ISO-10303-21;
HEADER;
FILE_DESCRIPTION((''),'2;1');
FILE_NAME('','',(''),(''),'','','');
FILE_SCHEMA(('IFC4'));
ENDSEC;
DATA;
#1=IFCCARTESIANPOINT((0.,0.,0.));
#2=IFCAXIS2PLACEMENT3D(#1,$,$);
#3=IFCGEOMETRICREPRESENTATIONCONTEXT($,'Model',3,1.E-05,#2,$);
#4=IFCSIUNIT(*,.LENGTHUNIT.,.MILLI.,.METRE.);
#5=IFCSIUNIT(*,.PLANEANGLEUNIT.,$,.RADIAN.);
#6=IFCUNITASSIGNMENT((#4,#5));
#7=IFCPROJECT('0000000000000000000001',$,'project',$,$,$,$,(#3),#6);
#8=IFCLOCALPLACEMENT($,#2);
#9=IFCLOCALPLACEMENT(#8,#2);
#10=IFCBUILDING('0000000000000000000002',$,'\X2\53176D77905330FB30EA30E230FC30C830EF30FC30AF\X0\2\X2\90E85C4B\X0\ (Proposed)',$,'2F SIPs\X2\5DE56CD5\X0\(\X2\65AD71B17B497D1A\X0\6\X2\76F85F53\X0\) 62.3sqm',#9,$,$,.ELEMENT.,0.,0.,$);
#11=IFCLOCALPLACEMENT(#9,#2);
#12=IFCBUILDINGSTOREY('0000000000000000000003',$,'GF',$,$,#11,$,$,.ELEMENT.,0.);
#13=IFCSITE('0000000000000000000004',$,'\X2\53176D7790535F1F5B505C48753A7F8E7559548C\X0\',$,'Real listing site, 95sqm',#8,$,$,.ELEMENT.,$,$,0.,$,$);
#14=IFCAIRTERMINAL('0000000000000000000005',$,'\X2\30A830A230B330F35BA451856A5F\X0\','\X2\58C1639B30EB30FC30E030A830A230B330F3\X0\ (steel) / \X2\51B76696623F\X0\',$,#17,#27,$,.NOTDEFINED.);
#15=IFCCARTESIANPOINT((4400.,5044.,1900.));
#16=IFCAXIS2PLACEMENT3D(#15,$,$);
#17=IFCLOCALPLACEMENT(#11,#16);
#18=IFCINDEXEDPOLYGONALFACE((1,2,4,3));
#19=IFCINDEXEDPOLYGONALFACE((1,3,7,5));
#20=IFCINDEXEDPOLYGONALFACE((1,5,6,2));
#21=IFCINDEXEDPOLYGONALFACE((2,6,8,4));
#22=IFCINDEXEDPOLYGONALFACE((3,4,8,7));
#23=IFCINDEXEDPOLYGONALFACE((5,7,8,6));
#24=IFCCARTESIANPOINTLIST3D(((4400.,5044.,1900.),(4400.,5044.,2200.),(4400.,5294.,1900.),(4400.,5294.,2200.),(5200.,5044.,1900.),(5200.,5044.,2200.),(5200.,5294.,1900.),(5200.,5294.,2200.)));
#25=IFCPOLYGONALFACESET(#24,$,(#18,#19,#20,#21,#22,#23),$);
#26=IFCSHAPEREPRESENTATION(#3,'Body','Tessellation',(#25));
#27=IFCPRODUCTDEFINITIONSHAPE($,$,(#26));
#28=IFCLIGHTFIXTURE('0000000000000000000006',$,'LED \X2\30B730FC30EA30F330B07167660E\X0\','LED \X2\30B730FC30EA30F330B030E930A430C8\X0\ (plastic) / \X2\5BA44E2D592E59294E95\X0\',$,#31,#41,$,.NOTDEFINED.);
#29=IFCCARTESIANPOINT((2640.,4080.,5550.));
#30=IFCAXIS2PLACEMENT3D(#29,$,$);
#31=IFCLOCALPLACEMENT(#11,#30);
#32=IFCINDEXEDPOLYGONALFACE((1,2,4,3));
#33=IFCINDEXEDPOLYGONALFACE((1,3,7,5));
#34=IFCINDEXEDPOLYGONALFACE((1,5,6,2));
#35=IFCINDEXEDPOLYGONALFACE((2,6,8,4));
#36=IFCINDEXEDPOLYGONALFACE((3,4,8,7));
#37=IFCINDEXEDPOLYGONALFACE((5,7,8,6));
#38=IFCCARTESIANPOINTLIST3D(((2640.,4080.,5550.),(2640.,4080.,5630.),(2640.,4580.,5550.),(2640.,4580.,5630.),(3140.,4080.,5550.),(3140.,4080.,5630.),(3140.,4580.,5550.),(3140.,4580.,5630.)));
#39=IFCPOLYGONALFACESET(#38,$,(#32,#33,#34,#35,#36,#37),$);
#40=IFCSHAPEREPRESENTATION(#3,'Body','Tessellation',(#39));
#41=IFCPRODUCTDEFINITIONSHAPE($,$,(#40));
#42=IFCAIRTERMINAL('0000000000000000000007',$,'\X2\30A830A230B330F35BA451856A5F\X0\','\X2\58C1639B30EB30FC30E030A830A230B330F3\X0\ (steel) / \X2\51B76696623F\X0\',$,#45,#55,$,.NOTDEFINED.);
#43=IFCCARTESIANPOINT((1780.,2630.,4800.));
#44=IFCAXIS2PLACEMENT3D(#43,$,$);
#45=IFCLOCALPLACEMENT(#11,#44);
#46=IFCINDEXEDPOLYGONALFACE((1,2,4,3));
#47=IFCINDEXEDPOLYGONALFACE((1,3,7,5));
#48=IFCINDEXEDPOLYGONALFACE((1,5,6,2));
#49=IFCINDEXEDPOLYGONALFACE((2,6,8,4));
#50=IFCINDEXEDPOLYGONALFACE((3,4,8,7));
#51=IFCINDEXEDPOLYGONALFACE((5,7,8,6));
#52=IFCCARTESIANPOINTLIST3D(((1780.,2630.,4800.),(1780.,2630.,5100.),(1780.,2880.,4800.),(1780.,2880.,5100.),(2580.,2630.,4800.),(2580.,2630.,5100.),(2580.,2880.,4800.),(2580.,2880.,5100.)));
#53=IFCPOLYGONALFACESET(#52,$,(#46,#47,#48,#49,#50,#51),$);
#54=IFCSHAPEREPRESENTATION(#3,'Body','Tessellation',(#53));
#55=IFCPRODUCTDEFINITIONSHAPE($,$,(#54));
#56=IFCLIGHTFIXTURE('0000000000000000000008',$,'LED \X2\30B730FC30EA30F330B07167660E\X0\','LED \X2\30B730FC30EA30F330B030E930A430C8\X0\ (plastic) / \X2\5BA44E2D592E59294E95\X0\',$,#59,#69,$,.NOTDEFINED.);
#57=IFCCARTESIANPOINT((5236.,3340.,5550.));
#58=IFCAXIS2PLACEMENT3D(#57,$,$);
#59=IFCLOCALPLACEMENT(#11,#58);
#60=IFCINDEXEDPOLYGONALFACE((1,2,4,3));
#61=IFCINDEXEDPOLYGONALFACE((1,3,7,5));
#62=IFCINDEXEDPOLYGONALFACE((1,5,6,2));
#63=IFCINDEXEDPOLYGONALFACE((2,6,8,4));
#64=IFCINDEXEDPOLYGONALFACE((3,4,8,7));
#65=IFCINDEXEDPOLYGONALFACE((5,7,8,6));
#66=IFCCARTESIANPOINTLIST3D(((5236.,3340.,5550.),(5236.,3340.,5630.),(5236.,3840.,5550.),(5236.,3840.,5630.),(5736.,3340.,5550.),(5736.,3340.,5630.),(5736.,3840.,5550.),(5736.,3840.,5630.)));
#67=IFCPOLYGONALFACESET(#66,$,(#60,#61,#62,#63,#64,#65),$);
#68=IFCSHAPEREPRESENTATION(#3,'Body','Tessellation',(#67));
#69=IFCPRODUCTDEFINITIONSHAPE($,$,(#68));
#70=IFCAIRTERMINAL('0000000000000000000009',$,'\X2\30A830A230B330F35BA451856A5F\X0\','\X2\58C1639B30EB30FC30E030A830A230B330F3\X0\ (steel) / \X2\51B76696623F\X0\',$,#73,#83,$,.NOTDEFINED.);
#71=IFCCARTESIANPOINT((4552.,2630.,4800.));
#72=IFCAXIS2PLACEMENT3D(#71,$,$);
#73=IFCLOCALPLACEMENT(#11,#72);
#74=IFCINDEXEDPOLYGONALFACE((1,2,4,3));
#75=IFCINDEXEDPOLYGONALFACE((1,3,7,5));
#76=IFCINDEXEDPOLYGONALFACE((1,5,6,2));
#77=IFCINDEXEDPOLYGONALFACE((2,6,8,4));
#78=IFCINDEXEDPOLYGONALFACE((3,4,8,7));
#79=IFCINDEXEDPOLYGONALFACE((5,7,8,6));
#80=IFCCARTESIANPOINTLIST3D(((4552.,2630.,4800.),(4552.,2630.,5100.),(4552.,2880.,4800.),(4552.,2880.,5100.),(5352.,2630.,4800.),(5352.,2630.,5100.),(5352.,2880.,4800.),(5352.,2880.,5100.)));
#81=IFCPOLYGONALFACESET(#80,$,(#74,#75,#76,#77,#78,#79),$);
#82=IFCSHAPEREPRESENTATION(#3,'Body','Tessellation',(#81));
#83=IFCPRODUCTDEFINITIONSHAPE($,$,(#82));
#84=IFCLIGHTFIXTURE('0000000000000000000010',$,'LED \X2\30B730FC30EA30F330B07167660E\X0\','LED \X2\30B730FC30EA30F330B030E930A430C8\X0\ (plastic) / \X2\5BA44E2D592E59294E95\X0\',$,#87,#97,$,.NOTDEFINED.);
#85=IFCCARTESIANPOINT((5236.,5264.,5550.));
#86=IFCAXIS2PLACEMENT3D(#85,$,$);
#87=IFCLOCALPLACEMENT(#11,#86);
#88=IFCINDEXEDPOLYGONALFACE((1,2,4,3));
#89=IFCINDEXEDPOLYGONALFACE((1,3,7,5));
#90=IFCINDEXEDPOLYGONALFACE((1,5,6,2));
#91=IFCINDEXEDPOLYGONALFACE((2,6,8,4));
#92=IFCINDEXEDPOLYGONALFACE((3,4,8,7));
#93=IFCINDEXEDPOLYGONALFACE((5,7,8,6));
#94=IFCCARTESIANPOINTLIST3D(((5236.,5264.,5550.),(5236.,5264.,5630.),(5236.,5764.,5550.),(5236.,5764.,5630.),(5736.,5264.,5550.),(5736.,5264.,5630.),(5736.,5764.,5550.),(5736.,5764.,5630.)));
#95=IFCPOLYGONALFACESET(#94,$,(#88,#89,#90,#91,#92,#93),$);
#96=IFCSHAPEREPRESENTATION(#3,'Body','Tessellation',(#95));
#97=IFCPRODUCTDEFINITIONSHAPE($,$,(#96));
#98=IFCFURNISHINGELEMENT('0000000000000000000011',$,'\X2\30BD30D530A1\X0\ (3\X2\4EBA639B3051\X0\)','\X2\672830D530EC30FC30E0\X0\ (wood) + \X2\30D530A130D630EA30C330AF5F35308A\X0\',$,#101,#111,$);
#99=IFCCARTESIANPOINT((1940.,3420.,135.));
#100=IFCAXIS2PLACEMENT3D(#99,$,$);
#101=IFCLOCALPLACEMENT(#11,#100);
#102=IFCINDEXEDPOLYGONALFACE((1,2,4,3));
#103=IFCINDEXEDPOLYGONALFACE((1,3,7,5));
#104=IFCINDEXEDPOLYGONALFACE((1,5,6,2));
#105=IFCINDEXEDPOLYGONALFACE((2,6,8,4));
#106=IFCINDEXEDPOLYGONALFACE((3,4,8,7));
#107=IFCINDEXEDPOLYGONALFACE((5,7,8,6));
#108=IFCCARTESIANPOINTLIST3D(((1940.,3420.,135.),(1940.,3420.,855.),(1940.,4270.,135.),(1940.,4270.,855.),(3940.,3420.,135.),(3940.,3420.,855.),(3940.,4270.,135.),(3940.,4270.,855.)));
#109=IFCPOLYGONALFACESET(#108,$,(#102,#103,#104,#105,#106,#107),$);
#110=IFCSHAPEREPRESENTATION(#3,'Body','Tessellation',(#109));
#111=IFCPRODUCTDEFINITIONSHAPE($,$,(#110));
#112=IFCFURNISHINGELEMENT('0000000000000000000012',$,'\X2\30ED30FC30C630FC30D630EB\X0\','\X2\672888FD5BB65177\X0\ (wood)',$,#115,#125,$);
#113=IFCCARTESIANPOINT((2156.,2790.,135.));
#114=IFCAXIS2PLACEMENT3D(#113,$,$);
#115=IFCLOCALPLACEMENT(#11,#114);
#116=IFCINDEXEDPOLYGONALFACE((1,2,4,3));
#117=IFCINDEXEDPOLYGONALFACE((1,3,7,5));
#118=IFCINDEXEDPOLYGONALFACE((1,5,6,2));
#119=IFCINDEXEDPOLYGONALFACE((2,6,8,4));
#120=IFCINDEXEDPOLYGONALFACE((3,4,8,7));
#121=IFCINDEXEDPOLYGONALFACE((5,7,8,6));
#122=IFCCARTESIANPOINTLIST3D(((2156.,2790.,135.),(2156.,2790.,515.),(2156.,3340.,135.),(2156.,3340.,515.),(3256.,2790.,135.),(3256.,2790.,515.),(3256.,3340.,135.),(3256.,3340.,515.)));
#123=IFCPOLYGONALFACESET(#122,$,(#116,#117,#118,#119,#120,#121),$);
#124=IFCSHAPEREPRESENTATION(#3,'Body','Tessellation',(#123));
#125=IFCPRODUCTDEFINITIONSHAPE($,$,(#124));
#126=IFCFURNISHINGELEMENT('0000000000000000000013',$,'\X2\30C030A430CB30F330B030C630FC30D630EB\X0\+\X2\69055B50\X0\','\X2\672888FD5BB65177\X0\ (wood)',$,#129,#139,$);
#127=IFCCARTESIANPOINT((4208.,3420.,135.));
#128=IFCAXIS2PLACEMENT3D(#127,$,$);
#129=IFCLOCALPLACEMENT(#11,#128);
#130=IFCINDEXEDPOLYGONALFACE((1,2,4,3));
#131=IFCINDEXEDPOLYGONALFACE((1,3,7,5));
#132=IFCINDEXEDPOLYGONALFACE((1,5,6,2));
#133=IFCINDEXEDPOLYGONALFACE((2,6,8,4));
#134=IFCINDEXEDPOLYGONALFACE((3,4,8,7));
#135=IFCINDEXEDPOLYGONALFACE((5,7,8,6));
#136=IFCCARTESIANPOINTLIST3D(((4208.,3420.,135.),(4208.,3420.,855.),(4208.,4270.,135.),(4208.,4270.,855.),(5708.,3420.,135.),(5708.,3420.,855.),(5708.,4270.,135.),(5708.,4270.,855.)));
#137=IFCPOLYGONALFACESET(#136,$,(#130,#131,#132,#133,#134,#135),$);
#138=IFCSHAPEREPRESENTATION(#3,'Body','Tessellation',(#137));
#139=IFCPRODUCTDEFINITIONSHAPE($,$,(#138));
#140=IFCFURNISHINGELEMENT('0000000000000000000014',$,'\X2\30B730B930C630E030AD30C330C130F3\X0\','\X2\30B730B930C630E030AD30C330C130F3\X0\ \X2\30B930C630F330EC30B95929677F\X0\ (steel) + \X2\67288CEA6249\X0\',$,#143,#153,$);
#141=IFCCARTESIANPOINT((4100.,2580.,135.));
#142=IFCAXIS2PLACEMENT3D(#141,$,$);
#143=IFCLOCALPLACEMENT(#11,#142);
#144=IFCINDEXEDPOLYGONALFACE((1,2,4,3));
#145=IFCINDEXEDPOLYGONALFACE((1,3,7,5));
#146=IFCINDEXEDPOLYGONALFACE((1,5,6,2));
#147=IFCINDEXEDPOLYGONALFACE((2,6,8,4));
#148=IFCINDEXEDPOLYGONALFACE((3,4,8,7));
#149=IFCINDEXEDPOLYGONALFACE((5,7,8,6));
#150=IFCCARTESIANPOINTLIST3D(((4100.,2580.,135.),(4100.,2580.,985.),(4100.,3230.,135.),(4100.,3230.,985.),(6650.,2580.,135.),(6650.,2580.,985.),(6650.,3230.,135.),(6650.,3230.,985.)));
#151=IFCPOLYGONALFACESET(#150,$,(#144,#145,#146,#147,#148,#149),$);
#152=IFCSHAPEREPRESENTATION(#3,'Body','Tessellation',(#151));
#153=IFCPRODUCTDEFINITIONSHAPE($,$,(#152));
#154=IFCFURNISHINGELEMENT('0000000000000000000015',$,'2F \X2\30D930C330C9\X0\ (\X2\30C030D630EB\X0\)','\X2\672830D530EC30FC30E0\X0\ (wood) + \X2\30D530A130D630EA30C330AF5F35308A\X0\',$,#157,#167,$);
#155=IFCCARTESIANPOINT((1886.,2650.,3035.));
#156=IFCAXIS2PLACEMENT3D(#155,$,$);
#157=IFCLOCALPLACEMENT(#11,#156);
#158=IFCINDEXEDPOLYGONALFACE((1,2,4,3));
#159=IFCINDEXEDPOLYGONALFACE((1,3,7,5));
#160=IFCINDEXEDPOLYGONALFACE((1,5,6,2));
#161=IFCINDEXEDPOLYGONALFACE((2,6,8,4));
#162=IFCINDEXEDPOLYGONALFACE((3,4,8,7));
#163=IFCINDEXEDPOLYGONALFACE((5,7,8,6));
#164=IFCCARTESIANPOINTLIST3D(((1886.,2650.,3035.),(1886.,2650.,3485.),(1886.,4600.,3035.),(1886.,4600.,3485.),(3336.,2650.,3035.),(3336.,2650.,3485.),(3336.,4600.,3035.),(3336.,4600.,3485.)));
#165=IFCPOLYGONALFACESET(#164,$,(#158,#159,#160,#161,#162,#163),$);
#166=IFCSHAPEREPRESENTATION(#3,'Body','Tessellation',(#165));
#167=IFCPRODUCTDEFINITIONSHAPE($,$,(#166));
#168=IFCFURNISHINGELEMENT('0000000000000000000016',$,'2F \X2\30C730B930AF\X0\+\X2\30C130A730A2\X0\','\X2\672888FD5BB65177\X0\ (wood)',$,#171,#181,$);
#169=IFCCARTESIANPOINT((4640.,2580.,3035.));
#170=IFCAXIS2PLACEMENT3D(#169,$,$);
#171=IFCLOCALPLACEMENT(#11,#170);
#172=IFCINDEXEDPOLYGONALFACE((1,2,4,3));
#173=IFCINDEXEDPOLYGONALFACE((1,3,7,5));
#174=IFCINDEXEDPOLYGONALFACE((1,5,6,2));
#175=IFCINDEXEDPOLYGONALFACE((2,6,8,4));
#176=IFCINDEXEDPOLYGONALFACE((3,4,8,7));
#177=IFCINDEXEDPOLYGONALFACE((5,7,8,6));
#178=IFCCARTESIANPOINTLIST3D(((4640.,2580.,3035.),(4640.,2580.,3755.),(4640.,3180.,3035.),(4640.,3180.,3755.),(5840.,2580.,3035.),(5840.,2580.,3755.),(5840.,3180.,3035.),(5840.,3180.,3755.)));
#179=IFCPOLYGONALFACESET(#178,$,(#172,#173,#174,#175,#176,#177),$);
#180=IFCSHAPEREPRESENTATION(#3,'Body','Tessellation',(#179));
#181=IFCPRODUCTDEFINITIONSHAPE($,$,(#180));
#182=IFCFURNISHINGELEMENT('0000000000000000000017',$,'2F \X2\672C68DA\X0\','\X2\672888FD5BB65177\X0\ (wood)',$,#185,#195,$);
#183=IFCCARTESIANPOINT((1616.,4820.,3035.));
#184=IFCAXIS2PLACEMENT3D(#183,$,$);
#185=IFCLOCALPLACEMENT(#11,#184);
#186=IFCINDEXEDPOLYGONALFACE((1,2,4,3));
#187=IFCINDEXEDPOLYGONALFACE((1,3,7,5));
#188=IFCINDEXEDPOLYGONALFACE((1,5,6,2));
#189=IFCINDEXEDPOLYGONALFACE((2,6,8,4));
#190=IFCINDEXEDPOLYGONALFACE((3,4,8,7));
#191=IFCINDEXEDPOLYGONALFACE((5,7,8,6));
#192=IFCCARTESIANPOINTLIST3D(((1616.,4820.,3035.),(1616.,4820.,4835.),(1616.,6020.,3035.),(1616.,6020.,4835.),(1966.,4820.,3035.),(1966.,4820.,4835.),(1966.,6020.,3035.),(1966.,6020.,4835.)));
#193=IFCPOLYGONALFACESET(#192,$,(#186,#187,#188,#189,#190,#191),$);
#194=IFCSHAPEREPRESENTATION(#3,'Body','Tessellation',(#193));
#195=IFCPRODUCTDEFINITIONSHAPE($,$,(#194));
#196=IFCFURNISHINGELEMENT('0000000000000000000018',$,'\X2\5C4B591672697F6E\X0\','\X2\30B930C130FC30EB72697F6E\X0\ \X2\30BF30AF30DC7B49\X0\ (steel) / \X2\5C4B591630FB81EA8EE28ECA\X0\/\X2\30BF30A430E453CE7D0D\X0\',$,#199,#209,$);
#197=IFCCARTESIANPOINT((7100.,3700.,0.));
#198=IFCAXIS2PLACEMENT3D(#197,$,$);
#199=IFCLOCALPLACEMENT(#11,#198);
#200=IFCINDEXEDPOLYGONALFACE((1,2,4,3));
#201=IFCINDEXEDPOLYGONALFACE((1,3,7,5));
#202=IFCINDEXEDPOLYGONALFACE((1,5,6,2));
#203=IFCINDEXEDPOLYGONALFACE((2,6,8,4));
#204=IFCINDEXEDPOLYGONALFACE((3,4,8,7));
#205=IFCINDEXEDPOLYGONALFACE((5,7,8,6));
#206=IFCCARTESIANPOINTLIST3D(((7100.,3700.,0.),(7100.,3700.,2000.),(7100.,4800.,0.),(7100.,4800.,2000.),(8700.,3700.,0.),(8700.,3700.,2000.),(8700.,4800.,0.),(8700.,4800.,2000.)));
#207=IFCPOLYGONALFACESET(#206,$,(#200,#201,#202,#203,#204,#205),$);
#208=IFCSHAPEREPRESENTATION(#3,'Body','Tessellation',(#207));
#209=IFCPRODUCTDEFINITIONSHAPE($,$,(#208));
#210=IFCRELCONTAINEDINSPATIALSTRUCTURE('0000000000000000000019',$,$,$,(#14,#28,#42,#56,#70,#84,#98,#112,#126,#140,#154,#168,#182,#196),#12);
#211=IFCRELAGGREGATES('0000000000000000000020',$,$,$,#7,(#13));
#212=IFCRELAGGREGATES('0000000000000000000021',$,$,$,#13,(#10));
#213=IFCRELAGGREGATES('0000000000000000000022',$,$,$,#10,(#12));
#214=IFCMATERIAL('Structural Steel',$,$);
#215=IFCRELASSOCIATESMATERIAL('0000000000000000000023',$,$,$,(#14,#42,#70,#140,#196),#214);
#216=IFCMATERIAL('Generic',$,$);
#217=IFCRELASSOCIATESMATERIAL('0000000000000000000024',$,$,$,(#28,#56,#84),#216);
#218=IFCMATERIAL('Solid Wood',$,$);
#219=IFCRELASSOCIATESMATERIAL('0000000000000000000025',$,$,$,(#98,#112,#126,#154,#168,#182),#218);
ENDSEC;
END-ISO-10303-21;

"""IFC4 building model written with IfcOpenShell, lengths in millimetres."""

from ifc_helpers import new_model, si_unit, frame, frame_2d, origin, place, context, project, spatial, rectangle, extrude, material, element, save


model = new_model("IFC4")

# Units and contexts
model_context = context("Model", 3, precision=1e-05, world=origin())
ifc_project = project(units=[si_unit("LENGTHUNIT", "METRE", prefix="MILLI"), si_unit("PLANEANGLEUNIT", "RADIAN")], contexts=[model_context])

# Site, building, storey
site_placement = place(None, origin())
site = spatial("IfcSite", under=ifc_project, at=site_placement, Name="北海道弟子屈町美留和", ObjectType="Real listing site, 95sqm", CompositionType="ELEMENT", RefElevation=0.0)
building_placement = place(site_placement, origin())
building = spatial("IfcBuilding", under=site, at=building_placement, Name="北海道・リモートワーク2部屋 (Proposed)", ObjectType="2F SIPs工法(断熱等級6相当) 62.3sqm", CompositionType="ELEMENT", ElevationOfRefHeight=0.0, ElevationOfTerrain=0.0)
storey_placement = place(building_placement, origin())
storey = spatial("IfcBuildingStorey", under=building, at=storey_placement, Name="GF", CompositionType="ELEMENT", Elevation=0.0)

# Shared definitions
ifc_material_1 = material(Name="Solid Wood")

# Shared definitions
ifc_material_2 = material(Name="Structural Steel")

# Shared definitions
ifc_material_3 = material(Name="Generic")

# Air terminal
air_terminal_1_placement = place(storey_placement, frame((4400.0, 5044.0, 1900.0)))
element("IfcAirTerminal", 1, at=air_terminal_1_placement, inside=storey, material=ifc_material_2, Name="エアコン室内機", Description="壁掛ルームエアコン (steel) / 冷暖房", PredefinedType="NOTDEFINED", context=model_context, shape_type="SweptSolid", body=[
    extrude(rectangle(XDim=800.0, YDim=250.0, at=frame_2d((400.0, 125.0))), frame((4400.0, 5044.0, 1900.0)), (0.0, 0.0, 1.0), 300.0),
])

# Light fixture
light_fixture_1_placement = place(storey_placement, frame((2640.0, 4080.0, 5550.0)))
element("IfcLightFixture", 2, at=light_fixture_1_placement, inside=storey, material=ifc_material_3, Name="LED シーリング照明", Description="LED シーリングライト (plastic) / 室中央天井", PredefinedType="NOTDEFINED", context=model_context, shape_type="SweptSolid", body=[
    extrude(rectangle(XDim=500.0, YDim=500.0, at=frame_2d((250.0, 250.0))), frame((2640.0, 4080.0, 5550.0)), (0.0, 0.0, 1.0), 80.0),
])

# Air terminal
air_terminal_2_placement = place(storey_placement, frame((1780.0, 2630.0, 4800.0)))
element("IfcAirTerminal", 3, at=air_terminal_2_placement, inside=storey, material=ifc_material_2, Name="エアコン室内機", Description="壁掛ルームエアコン (steel) / 冷暖房", PredefinedType="NOTDEFINED", context=model_context, shape_type="SweptSolid", body=[
    extrude(rectangle(XDim=800.0, YDim=250.0, at=frame_2d((400.0, 125.0))), frame((1780.0, 2630.0, 4800.0)), (0.0, 0.0, 1.0), 300.0),
])

# Light fixture
light_fixture_2_placement = place(storey_placement, frame((5236.0, 3340.0, 5550.0)))
element("IfcLightFixture", 4, at=light_fixture_2_placement, inside=storey, material=ifc_material_3, Name="LED シーリング照明", Description="LED シーリングライト (plastic) / 室中央天井", PredefinedType="NOTDEFINED", context=model_context, shape_type="SweptSolid", body=[
    extrude(rectangle(XDim=500.0, YDim=500.0, at=frame_2d((250.0, 250.0))), frame((5236.0, 3340.0, 5550.0)), (0.0, 0.0, 1.0), 80.0),
])

# Air terminal
air_terminal_3_placement = place(storey_placement, frame((4552.0, 2630.0, 4800.0)))
element("IfcAirTerminal", 5, at=air_terminal_3_placement, inside=storey, material=ifc_material_2, Name="エアコン室内機", Description="壁掛ルームエアコン (steel) / 冷暖房", PredefinedType="NOTDEFINED", context=model_context, shape_type="SweptSolid", body=[
    extrude(rectangle(XDim=800.0, YDim=250.0, at=frame_2d((400.0, 125.0))), frame((4552.0, 2630.0, 4800.0)), (0.0, 0.0, 1.0), 300.0),
])

# Light fixture
light_fixture_3_placement = place(storey_placement, frame((5236.0, 5264.0, 5550.0)))
element("IfcLightFixture", 6, at=light_fixture_3_placement, inside=storey, material=ifc_material_3, Name="LED シーリング照明", Description="LED シーリングライト (plastic) / 室中央天井", PredefinedType="NOTDEFINED", context=model_context, shape_type="SweptSolid", body=[
    extrude(rectangle(XDim=500.0, YDim=500.0, at=frame_2d((250.0, 250.0))), frame((5236.0, 5264.0, 5550.0)), (0.0, 0.0, 1.0), 80.0),
])

# Furnishing elements
furnishing_1_placement = place(storey_placement, frame((1940.0, 3420.0, 135.0)))
element("IfcFurnishingElement", 7, at=furnishing_1_placement, inside=storey, material=ifc_material_1, Name="ソファ (3人掛け)", Description="木フレーム (wood) + ファブリック張り", context=model_context, shape_type="SweptSolid", body=[
    extrude(rectangle(XDim=2000.0, YDim=850.0, at=frame_2d((1000.0, 425.0))), frame((1940.0, 3420.0, 135.0)), (0.0, 0.0, 1.0), 720.0),
])
furnishing_2_placement = place(storey_placement, frame((2156.0, 2790.0, 135.0)))
element("IfcFurnishingElement", 8, at=furnishing_2_placement, inside=storey, material=ifc_material_1, Name="ローテーブル", Description="木製家具 (wood)", context=model_context, shape_type="SweptSolid", body=[
    extrude(rectangle(XDim=1100.0, YDim=550.0, at=frame_2d((550.0, 275.0))), frame((2156.0, 2790.0, 135.0)), (0.0, 0.0, 1.0), 380.0),
])
furnishing_3_placement = place(storey_placement, frame((4208.0, 3420.0, 135.0)))
element("IfcFurnishingElement", 9, at=furnishing_3_placement, inside=storey, material=ifc_material_1, Name="ダイニングテーブル+椅子", Description="木製家具 (wood)", context=model_context, shape_type="SweptSolid", body=[
    extrude(rectangle(XDim=1500.0, YDim=850.0, at=frame_2d((750.0, 425.0))), frame((4208.0, 3420.0, 135.0)), (0.0, 0.0, 1.0), 720.0),
])
furnishing_4_placement = place(storey_placement, frame((4100.0, 2580.0, 135.0)))
element("IfcFurnishingElement", 10, at=furnishing_4_placement, inside=storey, material=ifc_material_2, Name="システムキッチン", Description="システムキッチン ステンレス天板 (steel) + 木質扉", context=model_context, shape_type="SweptSolid", body=[
    extrude(rectangle(XDim=2550.0, YDim=650.0, at=frame_2d((1275.0, 325.0))), frame((4100.0, 2580.0, 135.0)), (0.0, 0.0, 1.0), 850.0),
])
furnishing_5_placement = place(storey_placement, frame((1886.0, 2650.0, 3035.0)))
element("IfcFurnishingElement", 11, at=furnishing_5_placement, inside=storey, material=ifc_material_1, Name="2F ベッド (ダブル)", Description="木フレーム (wood) + ファブリック張り", context=model_context, shape_type="SweptSolid", body=[
    extrude(rectangle(XDim=1450.0, YDim=1950.0, at=frame_2d((725.0, 975.0))), frame((1886.0, 2650.0, 3035.0)), (0.0, 0.0, 1.0), 450.0),
])
furnishing_6_placement = place(storey_placement, frame((4640.0, 2580.0, 3035.0)))
element("IfcFurnishingElement", 12, at=furnishing_6_placement, inside=storey, material=ifc_material_1, Name="2F デスク+チェア", Description="木製家具 (wood)", context=model_context, shape_type="SweptSolid", body=[
    extrude(rectangle(XDim=1200.0, YDim=600.0, at=frame_2d((600.0, 300.0))), frame((4640.0, 2580.0, 3035.0)), (0.0, 0.0, 1.0), 720.0),
])
furnishing_7_placement = place(storey_placement, frame((1616.0, 4820.0, 3035.0)))
element("IfcFurnishingElement", 13, at=furnishing_7_placement, inside=storey, material=ifc_material_1, Name="2F 本棚", Description="木製家具 (wood)", context=model_context, shape_type="SweptSolid", body=[
    extrude(rectangle(XDim=350.0, YDim=1200.0, at=frame_2d((175.0, 600.0))), frame((1616.0, 4820.0, 3035.0)), (0.0, 0.0, 1.0), 1800.0),
])
furnishing_8_placement = place(storey_placement, frame((7100.0, 3700.0, 0.0)))
element("IfcFurnishingElement", 14, at=furnishing_8_placement, inside=storey, material=ifc_material_2, Name="屋外物置", Description="スチール物置 タクボ等 (steel) / 屋外・自転車/タイヤ収納", context=model_context, shape_type="SweptSolid", body=[
    extrude(rectangle(XDim=1600.0, YDim=1100.0, at=frame_2d((800.0, 550.0))), frame((7100.0, 3700.0, 0.0)), (0.0, 0.0, 1.0), 2000.0),
])

save(model, "model.ifc")
